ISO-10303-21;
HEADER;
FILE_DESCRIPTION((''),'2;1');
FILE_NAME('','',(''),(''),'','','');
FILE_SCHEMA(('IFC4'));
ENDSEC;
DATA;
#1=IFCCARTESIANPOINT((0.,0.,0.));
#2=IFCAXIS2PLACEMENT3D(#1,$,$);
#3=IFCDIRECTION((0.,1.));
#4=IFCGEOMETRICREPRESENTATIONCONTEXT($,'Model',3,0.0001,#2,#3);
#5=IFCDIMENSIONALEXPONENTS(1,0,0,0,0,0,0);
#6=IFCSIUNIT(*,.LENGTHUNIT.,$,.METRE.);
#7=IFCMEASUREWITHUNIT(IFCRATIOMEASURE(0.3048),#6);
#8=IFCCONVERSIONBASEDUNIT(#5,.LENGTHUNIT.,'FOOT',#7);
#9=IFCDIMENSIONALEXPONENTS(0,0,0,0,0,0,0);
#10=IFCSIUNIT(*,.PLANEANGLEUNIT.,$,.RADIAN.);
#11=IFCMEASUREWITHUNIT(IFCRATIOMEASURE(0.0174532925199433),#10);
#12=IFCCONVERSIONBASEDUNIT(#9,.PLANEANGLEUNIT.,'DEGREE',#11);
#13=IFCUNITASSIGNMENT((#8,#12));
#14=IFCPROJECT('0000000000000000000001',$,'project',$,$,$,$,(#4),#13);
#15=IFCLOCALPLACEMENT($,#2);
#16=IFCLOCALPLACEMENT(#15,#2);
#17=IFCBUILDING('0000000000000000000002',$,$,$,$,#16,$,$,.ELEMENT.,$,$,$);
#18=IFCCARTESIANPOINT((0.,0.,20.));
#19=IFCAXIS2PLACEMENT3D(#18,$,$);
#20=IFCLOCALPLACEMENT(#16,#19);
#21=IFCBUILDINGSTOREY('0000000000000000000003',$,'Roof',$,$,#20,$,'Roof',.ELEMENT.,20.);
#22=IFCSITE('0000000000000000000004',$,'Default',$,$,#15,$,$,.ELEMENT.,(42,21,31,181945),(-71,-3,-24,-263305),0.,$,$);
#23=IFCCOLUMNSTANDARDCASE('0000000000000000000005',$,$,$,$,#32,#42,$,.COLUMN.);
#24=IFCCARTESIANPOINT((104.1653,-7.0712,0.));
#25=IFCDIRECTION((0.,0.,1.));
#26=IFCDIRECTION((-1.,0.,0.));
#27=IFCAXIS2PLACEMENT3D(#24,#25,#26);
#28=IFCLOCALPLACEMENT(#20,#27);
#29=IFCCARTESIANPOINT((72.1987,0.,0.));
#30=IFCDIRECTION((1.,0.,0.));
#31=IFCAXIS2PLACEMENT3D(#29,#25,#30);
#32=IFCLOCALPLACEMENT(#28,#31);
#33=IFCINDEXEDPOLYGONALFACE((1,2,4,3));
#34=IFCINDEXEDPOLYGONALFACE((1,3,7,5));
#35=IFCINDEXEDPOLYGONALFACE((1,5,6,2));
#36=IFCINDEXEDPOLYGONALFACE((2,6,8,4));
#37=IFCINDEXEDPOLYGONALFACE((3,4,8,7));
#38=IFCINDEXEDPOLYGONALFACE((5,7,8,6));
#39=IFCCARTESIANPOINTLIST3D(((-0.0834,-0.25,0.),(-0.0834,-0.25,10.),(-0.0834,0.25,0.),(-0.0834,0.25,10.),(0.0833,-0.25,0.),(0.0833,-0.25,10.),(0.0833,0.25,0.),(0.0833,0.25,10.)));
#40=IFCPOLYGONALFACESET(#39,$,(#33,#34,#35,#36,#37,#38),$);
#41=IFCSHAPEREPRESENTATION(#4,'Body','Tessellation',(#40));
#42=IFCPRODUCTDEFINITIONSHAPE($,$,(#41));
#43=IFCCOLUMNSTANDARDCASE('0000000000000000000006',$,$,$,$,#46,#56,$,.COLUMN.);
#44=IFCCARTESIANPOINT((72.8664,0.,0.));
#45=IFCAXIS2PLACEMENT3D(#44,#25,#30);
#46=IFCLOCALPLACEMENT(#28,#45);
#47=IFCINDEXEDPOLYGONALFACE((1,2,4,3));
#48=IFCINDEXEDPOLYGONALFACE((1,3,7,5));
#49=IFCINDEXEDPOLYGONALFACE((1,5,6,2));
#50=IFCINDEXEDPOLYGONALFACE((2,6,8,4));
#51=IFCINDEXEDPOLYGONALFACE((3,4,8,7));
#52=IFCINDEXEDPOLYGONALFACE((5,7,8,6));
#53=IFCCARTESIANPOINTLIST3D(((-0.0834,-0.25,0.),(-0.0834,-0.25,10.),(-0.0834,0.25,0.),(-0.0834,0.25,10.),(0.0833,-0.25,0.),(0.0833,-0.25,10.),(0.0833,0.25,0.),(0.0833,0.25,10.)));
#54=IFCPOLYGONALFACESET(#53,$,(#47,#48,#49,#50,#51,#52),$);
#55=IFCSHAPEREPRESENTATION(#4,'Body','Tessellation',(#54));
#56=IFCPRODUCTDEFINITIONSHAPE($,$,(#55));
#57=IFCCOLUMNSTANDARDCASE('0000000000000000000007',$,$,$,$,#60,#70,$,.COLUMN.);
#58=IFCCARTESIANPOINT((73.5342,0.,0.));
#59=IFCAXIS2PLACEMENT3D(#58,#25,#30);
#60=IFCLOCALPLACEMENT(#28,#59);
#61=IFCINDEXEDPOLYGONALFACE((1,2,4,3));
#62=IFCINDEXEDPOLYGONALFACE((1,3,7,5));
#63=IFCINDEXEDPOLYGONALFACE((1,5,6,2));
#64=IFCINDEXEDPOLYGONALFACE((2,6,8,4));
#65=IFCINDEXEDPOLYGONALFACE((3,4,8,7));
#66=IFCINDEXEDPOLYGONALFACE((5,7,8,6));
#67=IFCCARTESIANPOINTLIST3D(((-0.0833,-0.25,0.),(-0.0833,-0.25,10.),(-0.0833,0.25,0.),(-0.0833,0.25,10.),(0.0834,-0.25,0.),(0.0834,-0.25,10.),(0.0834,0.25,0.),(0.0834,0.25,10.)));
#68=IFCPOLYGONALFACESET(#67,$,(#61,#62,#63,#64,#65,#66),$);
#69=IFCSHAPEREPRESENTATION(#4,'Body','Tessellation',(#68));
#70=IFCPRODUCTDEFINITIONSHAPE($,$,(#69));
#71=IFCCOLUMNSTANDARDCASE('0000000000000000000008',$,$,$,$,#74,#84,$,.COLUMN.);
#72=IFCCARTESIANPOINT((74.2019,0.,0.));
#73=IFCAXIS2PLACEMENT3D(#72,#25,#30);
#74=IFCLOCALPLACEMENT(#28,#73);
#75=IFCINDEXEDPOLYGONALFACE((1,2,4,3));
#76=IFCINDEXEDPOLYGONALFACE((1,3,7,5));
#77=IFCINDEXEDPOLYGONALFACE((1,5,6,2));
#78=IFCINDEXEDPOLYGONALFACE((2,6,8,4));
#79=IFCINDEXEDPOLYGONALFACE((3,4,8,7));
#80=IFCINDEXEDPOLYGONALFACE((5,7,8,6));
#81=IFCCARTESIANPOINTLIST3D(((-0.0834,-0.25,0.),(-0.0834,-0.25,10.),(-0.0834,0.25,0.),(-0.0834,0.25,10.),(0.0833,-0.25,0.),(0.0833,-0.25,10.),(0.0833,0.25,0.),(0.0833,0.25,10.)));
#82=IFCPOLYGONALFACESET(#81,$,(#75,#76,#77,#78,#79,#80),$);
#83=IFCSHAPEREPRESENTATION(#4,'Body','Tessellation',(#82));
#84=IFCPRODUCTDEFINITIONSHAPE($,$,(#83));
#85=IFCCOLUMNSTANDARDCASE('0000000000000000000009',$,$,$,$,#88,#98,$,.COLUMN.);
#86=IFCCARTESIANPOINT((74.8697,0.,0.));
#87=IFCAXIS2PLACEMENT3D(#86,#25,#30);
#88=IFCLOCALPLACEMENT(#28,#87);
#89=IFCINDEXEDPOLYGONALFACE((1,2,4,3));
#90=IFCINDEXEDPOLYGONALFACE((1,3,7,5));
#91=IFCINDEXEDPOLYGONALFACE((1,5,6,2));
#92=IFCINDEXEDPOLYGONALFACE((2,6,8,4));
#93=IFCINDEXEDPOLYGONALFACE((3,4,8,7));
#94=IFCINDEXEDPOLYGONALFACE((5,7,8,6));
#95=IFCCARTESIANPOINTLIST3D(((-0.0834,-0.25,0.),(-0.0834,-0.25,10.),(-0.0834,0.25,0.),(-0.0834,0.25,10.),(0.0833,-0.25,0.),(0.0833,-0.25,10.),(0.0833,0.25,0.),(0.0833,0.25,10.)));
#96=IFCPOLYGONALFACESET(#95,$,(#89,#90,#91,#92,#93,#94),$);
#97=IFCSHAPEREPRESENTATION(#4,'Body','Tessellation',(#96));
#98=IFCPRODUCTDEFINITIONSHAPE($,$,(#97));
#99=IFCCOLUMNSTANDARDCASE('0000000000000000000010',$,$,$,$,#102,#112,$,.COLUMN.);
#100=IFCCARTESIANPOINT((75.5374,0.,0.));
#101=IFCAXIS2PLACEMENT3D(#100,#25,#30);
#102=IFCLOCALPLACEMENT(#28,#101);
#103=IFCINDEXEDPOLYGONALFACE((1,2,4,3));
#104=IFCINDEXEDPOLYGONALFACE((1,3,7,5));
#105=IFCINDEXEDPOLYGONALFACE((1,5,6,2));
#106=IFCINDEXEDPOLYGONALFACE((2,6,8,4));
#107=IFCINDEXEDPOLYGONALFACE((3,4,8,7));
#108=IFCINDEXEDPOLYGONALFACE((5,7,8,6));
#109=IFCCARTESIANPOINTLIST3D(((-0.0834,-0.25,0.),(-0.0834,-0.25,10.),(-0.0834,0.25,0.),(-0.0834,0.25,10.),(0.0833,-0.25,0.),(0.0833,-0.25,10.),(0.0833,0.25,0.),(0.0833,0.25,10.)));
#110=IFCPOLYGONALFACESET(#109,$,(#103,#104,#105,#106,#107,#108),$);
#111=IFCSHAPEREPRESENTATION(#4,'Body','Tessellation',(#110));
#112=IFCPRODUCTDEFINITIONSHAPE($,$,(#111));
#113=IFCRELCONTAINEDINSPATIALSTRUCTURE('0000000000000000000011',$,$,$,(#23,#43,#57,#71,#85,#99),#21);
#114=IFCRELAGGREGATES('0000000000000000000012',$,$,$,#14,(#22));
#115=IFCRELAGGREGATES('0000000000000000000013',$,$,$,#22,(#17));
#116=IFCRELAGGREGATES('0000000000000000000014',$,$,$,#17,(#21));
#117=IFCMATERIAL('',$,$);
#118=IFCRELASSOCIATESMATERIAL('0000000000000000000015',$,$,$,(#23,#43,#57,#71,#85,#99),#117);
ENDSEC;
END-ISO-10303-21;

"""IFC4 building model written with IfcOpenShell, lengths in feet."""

from ifc_helpers import new_model, entity, si_unit, converted_unit, direction, frame, origin, place, context, project, spatial, rectangle, extrude, material, element, save


model = new_model("IFC4")

# Units and contexts
model_context = context("Model", 3, precision=0.0001, world=origin(), true_north=direction((0.0, 1.0)))
ifc_project = project(units=[converted_unit("LENGTHUNIT", "FOOT", entity("IfcRatioMeasure", 0.3048), si_unit("LENGTHUNIT", "METRE"), dimensions=[1, 0, 0, 0, 0, 0, 0]), converted_unit("PLANEANGLEUNIT", "DEGREE", entity("IfcRatioMeasure", 0.0174532925199433), si_unit("PLANEANGLEUNIT", "RADIAN"), dimensions=[0, 0, 0, 0, 0, 0, 0])], contexts=[model_context])

# Site, building, storey
site_placement = place(None, origin())
site = spatial("IfcSite", under=ifc_project, at=site_placement, Name="Default", CompositionType="ELEMENT", RefLatitude=(42, 21, 31, 181945), RefLongitude=(-71, -3, -24, -263305), RefElevation=0.0)
building_placement = place(site_placement, origin())
building = spatial("IfcBuilding", under=site, at=building_placement, CompositionType="ELEMENT")
storey_placement = place(building_placement, frame((0.0, 0.0, 20.0)))
storey = spatial("IfcBuildingStorey", under=building, at=storey_placement, Name="Roof", LongName="Roof", CompositionType="ELEMENT", Elevation=20.0)

# Columns
ifc_material = material(Name="")
placement = place(storey_placement, frame((104.1653, -7.0712, 0.0), z_axis=(0.0, 0.0, 1.0), x_axis=(-1.0, 0.0, 0.0)))
for number, where, z_axis, x_axis in (
    (1, (72.1987, 0.0, 0.0), (0.0, 0.0, 1.0), (1.0, 0.0, 0.0)),
    (2, (72.8664, 0.0, 0.0), (0.0, 0.0, 1.0), (1.0, 0.0, 0.0)),
    (3, (73.5342, 0.0, 0.0), (0.0, 0.0, 1.0), (1.0, 0.0, 0.0)),
    (4, (74.2019, 0.0, 0.0), (0.0, 0.0, 1.0), (1.0, 0.0, 0.0)),
    (5, (74.8697, 0.0, 0.0), (0.0, 0.0, 1.0), (1.0, 0.0, 0.0)),
    (6, (75.5374, 0.0, 0.0), (0.0, 0.0, 1.0), (1.0, 0.0, 0.0)),
):
    element("IfcColumnStandardCase", number, at=place(placement, frame(where, z_axis=z_axis, x_axis=x_axis)), inside=storey, material=ifc_material, PredefinedType="COLUMN", context=model_context, shape_type="SweptSolid", body=[
        extrude(rectangle(XDim=0.1667, YDim=0.5), origin(), (0.0, 0.0, 1.0), 10.0),
    ])

save(model, "model.ifc")
